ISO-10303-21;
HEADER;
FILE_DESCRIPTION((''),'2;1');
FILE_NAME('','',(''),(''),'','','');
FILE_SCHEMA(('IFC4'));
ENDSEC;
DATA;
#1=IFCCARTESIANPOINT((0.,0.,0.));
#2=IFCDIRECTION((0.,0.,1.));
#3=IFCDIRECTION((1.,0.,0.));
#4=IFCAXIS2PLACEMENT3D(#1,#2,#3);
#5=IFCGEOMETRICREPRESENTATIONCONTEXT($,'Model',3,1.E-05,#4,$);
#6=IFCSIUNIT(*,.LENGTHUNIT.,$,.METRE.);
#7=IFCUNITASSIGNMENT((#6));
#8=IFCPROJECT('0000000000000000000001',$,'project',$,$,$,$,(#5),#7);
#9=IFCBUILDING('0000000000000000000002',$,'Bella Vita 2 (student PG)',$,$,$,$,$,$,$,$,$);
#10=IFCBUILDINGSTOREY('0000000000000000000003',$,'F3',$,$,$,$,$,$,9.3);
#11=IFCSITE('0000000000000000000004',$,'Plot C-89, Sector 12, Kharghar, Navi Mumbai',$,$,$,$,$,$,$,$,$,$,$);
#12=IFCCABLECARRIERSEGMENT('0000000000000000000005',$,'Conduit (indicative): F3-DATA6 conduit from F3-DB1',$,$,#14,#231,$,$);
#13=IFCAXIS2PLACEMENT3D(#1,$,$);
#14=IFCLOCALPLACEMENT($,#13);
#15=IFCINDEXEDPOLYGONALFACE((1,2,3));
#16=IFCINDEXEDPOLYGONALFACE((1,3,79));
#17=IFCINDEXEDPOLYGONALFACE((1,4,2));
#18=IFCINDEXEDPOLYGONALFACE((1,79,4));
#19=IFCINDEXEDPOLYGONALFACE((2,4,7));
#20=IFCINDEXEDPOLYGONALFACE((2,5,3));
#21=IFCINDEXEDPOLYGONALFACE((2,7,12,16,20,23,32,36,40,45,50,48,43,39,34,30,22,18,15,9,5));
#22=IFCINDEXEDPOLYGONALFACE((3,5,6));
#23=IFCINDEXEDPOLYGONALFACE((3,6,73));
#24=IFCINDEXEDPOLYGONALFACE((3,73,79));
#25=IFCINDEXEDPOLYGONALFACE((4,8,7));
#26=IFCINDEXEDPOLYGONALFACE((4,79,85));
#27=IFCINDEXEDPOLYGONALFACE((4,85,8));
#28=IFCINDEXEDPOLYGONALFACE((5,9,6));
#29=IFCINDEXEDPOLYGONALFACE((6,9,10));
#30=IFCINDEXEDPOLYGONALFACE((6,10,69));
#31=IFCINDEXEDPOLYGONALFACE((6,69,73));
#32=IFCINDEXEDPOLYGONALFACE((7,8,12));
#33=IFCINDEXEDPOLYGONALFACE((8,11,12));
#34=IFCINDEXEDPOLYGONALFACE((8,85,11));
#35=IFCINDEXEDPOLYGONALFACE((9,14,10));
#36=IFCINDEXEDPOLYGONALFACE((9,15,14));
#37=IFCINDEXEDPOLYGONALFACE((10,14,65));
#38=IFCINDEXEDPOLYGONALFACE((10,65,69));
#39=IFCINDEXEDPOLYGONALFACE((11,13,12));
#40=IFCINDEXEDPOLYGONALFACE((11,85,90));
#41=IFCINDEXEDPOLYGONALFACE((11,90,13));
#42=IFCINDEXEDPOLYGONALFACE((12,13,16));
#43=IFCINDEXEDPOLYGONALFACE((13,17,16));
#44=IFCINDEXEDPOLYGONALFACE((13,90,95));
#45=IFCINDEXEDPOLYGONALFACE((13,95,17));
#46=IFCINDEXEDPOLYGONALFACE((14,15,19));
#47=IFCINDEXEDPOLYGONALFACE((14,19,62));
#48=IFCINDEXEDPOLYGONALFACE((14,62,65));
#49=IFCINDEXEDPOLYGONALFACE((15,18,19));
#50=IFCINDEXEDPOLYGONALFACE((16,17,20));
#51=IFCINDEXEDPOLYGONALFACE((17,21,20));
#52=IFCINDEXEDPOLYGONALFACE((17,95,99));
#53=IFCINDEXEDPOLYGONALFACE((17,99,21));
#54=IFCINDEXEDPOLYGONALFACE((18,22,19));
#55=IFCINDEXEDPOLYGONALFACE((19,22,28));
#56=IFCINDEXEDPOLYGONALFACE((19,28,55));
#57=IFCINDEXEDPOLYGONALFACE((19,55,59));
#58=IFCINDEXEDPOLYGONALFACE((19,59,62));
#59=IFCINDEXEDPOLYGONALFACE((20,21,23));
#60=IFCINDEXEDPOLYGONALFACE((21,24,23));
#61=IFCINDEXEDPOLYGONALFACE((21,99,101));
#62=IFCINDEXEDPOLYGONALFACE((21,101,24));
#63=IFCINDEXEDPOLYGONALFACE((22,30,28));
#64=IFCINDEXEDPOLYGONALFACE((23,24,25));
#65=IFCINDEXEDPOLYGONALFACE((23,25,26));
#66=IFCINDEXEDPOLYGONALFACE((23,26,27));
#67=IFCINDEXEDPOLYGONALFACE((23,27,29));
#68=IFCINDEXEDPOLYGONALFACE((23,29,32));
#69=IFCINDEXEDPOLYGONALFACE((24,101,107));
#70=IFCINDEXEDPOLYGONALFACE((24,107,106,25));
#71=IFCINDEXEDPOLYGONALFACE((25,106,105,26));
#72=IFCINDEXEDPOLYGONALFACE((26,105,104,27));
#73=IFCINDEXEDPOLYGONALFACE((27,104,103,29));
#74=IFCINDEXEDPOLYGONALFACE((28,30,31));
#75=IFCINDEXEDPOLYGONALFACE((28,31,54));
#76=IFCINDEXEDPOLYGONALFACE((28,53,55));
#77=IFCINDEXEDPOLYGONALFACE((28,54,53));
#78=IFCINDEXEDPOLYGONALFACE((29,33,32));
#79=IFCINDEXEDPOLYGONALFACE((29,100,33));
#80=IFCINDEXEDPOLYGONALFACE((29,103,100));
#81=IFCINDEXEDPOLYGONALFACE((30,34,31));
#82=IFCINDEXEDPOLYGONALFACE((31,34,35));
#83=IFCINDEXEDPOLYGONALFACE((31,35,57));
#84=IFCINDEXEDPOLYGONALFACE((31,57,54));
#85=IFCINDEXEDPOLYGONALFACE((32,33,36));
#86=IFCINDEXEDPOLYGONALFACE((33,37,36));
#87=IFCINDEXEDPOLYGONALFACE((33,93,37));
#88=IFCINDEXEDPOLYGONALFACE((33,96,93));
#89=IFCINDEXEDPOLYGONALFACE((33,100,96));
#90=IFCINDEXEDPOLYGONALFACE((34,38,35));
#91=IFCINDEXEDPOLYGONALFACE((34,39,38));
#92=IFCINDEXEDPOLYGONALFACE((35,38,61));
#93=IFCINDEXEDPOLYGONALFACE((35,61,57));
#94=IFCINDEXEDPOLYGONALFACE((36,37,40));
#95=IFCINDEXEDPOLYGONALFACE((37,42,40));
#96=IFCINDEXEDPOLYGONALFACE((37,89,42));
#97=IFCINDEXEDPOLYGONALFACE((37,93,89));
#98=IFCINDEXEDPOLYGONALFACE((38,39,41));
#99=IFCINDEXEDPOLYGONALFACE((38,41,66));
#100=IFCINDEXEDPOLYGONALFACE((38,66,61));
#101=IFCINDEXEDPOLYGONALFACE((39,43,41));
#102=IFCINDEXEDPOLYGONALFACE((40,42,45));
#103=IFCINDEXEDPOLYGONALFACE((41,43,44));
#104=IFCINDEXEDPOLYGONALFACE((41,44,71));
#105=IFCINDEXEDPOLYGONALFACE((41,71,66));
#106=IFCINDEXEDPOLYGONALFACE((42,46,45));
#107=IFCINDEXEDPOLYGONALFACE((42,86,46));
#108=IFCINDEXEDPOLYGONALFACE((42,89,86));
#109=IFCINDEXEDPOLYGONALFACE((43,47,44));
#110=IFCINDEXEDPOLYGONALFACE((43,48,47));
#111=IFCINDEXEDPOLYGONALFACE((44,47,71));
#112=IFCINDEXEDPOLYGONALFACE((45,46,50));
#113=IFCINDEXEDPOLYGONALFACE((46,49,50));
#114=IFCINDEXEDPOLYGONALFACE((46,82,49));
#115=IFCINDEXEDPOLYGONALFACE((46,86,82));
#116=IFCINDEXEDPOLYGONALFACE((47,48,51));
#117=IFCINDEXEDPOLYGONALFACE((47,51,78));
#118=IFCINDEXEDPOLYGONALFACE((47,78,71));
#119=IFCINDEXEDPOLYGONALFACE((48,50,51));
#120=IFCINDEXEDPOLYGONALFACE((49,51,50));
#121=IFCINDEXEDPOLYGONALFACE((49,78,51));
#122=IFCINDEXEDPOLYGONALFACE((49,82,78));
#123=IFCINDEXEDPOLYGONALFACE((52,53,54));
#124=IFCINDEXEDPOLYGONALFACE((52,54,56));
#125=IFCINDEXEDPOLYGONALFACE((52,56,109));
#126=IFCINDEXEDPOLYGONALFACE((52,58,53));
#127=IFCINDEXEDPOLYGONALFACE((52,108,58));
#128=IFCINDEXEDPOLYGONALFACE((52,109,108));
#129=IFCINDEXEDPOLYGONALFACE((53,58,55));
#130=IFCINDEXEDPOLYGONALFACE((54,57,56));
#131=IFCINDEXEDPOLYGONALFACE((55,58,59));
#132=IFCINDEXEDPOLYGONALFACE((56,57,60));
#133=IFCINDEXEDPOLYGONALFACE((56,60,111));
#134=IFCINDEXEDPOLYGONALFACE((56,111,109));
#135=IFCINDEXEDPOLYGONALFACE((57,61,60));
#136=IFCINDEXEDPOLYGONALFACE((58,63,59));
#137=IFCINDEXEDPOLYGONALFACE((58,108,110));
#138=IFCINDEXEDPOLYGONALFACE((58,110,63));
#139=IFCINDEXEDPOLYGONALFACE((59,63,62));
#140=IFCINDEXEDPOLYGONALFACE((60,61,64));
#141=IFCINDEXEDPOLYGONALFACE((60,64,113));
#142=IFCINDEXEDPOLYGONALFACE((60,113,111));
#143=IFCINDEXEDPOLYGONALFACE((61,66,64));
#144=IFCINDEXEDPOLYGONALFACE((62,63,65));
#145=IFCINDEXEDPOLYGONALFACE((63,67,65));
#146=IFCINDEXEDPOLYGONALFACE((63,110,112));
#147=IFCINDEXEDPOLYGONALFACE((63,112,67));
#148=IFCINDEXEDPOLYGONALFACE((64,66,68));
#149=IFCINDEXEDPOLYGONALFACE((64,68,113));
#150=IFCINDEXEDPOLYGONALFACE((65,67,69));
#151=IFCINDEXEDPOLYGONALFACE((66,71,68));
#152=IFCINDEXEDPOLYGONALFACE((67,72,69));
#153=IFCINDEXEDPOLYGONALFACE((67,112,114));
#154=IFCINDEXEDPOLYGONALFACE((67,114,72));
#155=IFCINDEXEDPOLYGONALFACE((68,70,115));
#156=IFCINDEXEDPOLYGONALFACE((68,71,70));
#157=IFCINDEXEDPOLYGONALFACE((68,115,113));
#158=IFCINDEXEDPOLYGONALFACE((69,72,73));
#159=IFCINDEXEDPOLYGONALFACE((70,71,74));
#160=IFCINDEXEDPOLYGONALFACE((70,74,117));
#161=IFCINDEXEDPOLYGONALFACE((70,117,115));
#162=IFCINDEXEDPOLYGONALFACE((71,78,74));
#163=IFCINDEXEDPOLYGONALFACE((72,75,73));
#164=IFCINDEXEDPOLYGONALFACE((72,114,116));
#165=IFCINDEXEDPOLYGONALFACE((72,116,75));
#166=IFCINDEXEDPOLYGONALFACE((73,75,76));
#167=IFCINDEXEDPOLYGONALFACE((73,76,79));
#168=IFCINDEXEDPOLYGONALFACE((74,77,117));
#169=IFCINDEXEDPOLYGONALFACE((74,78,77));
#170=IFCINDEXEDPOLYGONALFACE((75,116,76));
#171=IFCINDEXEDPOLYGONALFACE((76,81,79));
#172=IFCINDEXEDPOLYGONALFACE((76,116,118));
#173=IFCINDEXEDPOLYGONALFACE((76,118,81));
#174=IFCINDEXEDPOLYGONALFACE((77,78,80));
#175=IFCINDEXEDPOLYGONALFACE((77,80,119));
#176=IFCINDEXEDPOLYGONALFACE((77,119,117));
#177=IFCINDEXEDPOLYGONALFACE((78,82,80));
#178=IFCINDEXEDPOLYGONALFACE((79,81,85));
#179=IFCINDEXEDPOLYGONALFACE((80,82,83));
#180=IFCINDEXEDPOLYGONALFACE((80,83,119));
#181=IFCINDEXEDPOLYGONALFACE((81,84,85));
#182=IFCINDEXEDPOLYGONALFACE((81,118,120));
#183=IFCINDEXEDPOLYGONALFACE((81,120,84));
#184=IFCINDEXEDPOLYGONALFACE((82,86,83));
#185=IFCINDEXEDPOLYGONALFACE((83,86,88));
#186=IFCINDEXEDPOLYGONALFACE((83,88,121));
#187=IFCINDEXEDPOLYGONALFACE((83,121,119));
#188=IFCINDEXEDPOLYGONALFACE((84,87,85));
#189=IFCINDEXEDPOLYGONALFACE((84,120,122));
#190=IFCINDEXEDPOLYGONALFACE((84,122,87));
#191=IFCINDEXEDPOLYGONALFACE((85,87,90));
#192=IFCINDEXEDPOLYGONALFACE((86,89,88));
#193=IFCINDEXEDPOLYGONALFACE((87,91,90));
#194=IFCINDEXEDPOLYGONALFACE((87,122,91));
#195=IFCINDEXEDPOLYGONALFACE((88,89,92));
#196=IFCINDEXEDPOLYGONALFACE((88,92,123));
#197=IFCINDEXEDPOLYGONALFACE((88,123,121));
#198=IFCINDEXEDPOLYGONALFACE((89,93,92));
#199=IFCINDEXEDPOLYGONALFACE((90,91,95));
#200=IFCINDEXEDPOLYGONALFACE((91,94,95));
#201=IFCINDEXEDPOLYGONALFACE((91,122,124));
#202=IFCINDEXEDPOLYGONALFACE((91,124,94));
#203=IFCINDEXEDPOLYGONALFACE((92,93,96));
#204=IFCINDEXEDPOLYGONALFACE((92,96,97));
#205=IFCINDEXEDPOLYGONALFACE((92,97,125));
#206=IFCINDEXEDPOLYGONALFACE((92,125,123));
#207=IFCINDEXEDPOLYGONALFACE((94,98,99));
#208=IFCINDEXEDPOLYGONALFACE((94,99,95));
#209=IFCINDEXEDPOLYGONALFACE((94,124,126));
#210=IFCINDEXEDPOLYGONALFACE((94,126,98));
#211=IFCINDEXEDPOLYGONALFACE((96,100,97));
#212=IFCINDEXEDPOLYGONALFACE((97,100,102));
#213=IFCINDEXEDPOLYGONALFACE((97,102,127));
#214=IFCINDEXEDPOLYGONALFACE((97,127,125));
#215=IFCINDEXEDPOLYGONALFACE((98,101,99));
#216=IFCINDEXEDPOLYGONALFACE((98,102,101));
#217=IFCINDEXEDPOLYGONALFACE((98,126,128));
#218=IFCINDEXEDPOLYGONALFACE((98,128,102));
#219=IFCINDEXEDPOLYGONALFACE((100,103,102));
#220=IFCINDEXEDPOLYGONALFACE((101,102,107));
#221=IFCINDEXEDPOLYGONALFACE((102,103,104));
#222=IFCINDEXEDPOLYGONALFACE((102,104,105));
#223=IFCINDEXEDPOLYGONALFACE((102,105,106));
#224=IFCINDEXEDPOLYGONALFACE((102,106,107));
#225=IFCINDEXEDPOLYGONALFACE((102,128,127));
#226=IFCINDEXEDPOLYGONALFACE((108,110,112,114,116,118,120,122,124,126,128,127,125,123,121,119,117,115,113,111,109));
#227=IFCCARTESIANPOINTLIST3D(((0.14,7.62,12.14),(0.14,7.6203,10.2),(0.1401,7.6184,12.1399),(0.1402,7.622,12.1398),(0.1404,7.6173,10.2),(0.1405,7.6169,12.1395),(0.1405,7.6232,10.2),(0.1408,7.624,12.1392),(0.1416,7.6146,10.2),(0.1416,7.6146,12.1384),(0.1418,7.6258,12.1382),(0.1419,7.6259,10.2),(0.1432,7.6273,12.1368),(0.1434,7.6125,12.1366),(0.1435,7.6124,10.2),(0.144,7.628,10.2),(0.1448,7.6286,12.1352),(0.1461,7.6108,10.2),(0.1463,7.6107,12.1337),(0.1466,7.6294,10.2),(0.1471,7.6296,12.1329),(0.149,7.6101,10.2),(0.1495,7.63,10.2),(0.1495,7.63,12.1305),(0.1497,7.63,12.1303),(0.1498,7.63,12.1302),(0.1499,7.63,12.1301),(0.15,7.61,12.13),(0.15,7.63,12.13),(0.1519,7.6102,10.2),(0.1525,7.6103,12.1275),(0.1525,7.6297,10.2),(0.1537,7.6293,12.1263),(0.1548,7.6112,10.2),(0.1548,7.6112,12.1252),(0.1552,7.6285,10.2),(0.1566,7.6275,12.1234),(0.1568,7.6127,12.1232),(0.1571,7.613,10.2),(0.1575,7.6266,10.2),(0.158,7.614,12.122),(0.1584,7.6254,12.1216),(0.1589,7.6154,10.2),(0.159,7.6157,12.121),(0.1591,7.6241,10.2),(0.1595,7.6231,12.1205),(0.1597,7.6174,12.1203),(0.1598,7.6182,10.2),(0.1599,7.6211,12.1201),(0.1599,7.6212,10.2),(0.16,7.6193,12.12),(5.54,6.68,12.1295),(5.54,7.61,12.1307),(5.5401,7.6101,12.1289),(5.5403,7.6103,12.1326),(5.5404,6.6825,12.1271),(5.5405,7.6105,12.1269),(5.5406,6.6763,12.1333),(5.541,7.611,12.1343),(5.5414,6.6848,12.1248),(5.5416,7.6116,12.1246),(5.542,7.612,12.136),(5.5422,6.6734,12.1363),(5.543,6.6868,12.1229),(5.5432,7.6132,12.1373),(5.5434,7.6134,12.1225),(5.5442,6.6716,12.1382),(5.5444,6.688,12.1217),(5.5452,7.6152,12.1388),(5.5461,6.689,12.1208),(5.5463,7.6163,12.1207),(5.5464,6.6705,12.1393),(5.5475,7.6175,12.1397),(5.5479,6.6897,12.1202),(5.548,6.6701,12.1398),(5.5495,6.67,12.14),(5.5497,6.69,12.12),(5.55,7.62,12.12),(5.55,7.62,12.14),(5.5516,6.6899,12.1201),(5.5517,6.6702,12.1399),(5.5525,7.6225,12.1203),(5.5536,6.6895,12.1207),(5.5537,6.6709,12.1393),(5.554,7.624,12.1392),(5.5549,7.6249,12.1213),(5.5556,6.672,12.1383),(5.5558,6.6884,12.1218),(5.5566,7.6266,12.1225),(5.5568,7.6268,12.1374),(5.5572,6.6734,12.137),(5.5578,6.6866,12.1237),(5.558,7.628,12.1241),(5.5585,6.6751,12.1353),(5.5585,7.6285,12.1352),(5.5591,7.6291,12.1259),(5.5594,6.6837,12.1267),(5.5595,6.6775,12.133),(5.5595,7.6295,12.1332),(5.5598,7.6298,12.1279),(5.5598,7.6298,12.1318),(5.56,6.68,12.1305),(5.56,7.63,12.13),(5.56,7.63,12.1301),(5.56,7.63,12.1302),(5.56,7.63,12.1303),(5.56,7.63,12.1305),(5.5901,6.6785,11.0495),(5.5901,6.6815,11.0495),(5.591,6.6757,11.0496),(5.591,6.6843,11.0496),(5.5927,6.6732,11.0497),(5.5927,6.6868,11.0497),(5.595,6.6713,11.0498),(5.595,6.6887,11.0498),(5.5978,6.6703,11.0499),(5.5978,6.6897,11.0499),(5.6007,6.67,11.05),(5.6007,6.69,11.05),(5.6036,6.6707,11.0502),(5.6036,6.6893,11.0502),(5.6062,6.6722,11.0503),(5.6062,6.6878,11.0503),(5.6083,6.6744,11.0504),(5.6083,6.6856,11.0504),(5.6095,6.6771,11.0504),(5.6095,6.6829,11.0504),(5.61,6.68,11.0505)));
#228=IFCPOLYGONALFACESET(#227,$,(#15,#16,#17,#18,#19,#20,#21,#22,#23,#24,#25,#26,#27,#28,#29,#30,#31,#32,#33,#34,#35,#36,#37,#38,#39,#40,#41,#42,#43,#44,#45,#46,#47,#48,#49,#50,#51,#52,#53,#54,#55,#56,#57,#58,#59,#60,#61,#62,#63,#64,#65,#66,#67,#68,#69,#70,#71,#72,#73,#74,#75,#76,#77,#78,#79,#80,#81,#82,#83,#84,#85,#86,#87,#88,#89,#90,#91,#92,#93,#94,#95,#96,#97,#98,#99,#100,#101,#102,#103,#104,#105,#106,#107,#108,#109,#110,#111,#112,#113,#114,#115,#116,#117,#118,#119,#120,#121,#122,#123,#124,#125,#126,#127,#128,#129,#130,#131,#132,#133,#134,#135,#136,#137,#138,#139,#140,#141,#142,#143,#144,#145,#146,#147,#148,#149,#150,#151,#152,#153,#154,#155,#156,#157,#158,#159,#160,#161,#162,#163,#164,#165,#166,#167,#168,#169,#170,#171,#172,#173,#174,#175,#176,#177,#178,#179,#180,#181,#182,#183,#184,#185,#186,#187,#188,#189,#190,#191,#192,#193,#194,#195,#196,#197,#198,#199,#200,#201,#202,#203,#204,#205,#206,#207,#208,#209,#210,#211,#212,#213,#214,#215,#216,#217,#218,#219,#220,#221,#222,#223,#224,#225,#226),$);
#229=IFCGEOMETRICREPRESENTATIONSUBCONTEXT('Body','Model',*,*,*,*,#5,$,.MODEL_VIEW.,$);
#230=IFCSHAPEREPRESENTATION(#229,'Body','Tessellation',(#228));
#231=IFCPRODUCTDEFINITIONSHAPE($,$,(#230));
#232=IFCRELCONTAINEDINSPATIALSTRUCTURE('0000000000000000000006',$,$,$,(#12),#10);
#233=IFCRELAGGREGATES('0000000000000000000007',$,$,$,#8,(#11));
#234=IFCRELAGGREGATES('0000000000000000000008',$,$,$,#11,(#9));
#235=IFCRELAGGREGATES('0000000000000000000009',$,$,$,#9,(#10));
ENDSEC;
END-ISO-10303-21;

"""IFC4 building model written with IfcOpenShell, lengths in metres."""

from ifc_helpers import new_model, entity, si_unit, origin, origin_with_axes, place, context, subcontext, project, spatial, element, save


model = new_model("IFC4")

# Units and contexts
model_context = context("Model", 3, precision=1e-05, world=origin_with_axes())
body_context = subcontext(model_context, "Body", "Model", "MODEL_VIEW")
ifc_project = project(units=[si_unit("LENGTHUNIT", "METRE")], contexts=[model_context])

# Site, building, storey
site = spatial("IfcSite", under=ifc_project, Name="Plot C-89, Sector 12, Kharghar, Navi Mumbai")
building = spatial("IfcBuilding", under=site, Name="Bella Vita 2 (student PG)")
storey = spatial("IfcBuildingStorey", under=building, Name="F3", Elevation=9.3)

# Cable carrier segment
cable_carrier_segment_1_placement = place(None, origin())
element("IfcCableCarrierSegment", 1, at=cable_carrier_segment_1_placement, inside=storey, Name="Conduit (indicative): F3-DATA6 conduit from F3-DB1", context=body_context, shape_type="AdvancedSweptSolid", body=[
    entity("IfcSweptDiskSolid", entity("IfcPolyline", [entity("IfcCartesianPoint", [5.6, 6.68, 11.05]), entity("IfcCartesianPoint", [5.55, 6.68, 12.13]), entity("IfcCartesianPoint", [5.55, 7.62, 12.13]), entity("IfcCartesianPoint", [0.15, 7.62, 12.13]), entity("IfcCartesianPoint", [0.15, 7.62, 10.2])]), 0.01),
])

save(model, "model.ifc")
